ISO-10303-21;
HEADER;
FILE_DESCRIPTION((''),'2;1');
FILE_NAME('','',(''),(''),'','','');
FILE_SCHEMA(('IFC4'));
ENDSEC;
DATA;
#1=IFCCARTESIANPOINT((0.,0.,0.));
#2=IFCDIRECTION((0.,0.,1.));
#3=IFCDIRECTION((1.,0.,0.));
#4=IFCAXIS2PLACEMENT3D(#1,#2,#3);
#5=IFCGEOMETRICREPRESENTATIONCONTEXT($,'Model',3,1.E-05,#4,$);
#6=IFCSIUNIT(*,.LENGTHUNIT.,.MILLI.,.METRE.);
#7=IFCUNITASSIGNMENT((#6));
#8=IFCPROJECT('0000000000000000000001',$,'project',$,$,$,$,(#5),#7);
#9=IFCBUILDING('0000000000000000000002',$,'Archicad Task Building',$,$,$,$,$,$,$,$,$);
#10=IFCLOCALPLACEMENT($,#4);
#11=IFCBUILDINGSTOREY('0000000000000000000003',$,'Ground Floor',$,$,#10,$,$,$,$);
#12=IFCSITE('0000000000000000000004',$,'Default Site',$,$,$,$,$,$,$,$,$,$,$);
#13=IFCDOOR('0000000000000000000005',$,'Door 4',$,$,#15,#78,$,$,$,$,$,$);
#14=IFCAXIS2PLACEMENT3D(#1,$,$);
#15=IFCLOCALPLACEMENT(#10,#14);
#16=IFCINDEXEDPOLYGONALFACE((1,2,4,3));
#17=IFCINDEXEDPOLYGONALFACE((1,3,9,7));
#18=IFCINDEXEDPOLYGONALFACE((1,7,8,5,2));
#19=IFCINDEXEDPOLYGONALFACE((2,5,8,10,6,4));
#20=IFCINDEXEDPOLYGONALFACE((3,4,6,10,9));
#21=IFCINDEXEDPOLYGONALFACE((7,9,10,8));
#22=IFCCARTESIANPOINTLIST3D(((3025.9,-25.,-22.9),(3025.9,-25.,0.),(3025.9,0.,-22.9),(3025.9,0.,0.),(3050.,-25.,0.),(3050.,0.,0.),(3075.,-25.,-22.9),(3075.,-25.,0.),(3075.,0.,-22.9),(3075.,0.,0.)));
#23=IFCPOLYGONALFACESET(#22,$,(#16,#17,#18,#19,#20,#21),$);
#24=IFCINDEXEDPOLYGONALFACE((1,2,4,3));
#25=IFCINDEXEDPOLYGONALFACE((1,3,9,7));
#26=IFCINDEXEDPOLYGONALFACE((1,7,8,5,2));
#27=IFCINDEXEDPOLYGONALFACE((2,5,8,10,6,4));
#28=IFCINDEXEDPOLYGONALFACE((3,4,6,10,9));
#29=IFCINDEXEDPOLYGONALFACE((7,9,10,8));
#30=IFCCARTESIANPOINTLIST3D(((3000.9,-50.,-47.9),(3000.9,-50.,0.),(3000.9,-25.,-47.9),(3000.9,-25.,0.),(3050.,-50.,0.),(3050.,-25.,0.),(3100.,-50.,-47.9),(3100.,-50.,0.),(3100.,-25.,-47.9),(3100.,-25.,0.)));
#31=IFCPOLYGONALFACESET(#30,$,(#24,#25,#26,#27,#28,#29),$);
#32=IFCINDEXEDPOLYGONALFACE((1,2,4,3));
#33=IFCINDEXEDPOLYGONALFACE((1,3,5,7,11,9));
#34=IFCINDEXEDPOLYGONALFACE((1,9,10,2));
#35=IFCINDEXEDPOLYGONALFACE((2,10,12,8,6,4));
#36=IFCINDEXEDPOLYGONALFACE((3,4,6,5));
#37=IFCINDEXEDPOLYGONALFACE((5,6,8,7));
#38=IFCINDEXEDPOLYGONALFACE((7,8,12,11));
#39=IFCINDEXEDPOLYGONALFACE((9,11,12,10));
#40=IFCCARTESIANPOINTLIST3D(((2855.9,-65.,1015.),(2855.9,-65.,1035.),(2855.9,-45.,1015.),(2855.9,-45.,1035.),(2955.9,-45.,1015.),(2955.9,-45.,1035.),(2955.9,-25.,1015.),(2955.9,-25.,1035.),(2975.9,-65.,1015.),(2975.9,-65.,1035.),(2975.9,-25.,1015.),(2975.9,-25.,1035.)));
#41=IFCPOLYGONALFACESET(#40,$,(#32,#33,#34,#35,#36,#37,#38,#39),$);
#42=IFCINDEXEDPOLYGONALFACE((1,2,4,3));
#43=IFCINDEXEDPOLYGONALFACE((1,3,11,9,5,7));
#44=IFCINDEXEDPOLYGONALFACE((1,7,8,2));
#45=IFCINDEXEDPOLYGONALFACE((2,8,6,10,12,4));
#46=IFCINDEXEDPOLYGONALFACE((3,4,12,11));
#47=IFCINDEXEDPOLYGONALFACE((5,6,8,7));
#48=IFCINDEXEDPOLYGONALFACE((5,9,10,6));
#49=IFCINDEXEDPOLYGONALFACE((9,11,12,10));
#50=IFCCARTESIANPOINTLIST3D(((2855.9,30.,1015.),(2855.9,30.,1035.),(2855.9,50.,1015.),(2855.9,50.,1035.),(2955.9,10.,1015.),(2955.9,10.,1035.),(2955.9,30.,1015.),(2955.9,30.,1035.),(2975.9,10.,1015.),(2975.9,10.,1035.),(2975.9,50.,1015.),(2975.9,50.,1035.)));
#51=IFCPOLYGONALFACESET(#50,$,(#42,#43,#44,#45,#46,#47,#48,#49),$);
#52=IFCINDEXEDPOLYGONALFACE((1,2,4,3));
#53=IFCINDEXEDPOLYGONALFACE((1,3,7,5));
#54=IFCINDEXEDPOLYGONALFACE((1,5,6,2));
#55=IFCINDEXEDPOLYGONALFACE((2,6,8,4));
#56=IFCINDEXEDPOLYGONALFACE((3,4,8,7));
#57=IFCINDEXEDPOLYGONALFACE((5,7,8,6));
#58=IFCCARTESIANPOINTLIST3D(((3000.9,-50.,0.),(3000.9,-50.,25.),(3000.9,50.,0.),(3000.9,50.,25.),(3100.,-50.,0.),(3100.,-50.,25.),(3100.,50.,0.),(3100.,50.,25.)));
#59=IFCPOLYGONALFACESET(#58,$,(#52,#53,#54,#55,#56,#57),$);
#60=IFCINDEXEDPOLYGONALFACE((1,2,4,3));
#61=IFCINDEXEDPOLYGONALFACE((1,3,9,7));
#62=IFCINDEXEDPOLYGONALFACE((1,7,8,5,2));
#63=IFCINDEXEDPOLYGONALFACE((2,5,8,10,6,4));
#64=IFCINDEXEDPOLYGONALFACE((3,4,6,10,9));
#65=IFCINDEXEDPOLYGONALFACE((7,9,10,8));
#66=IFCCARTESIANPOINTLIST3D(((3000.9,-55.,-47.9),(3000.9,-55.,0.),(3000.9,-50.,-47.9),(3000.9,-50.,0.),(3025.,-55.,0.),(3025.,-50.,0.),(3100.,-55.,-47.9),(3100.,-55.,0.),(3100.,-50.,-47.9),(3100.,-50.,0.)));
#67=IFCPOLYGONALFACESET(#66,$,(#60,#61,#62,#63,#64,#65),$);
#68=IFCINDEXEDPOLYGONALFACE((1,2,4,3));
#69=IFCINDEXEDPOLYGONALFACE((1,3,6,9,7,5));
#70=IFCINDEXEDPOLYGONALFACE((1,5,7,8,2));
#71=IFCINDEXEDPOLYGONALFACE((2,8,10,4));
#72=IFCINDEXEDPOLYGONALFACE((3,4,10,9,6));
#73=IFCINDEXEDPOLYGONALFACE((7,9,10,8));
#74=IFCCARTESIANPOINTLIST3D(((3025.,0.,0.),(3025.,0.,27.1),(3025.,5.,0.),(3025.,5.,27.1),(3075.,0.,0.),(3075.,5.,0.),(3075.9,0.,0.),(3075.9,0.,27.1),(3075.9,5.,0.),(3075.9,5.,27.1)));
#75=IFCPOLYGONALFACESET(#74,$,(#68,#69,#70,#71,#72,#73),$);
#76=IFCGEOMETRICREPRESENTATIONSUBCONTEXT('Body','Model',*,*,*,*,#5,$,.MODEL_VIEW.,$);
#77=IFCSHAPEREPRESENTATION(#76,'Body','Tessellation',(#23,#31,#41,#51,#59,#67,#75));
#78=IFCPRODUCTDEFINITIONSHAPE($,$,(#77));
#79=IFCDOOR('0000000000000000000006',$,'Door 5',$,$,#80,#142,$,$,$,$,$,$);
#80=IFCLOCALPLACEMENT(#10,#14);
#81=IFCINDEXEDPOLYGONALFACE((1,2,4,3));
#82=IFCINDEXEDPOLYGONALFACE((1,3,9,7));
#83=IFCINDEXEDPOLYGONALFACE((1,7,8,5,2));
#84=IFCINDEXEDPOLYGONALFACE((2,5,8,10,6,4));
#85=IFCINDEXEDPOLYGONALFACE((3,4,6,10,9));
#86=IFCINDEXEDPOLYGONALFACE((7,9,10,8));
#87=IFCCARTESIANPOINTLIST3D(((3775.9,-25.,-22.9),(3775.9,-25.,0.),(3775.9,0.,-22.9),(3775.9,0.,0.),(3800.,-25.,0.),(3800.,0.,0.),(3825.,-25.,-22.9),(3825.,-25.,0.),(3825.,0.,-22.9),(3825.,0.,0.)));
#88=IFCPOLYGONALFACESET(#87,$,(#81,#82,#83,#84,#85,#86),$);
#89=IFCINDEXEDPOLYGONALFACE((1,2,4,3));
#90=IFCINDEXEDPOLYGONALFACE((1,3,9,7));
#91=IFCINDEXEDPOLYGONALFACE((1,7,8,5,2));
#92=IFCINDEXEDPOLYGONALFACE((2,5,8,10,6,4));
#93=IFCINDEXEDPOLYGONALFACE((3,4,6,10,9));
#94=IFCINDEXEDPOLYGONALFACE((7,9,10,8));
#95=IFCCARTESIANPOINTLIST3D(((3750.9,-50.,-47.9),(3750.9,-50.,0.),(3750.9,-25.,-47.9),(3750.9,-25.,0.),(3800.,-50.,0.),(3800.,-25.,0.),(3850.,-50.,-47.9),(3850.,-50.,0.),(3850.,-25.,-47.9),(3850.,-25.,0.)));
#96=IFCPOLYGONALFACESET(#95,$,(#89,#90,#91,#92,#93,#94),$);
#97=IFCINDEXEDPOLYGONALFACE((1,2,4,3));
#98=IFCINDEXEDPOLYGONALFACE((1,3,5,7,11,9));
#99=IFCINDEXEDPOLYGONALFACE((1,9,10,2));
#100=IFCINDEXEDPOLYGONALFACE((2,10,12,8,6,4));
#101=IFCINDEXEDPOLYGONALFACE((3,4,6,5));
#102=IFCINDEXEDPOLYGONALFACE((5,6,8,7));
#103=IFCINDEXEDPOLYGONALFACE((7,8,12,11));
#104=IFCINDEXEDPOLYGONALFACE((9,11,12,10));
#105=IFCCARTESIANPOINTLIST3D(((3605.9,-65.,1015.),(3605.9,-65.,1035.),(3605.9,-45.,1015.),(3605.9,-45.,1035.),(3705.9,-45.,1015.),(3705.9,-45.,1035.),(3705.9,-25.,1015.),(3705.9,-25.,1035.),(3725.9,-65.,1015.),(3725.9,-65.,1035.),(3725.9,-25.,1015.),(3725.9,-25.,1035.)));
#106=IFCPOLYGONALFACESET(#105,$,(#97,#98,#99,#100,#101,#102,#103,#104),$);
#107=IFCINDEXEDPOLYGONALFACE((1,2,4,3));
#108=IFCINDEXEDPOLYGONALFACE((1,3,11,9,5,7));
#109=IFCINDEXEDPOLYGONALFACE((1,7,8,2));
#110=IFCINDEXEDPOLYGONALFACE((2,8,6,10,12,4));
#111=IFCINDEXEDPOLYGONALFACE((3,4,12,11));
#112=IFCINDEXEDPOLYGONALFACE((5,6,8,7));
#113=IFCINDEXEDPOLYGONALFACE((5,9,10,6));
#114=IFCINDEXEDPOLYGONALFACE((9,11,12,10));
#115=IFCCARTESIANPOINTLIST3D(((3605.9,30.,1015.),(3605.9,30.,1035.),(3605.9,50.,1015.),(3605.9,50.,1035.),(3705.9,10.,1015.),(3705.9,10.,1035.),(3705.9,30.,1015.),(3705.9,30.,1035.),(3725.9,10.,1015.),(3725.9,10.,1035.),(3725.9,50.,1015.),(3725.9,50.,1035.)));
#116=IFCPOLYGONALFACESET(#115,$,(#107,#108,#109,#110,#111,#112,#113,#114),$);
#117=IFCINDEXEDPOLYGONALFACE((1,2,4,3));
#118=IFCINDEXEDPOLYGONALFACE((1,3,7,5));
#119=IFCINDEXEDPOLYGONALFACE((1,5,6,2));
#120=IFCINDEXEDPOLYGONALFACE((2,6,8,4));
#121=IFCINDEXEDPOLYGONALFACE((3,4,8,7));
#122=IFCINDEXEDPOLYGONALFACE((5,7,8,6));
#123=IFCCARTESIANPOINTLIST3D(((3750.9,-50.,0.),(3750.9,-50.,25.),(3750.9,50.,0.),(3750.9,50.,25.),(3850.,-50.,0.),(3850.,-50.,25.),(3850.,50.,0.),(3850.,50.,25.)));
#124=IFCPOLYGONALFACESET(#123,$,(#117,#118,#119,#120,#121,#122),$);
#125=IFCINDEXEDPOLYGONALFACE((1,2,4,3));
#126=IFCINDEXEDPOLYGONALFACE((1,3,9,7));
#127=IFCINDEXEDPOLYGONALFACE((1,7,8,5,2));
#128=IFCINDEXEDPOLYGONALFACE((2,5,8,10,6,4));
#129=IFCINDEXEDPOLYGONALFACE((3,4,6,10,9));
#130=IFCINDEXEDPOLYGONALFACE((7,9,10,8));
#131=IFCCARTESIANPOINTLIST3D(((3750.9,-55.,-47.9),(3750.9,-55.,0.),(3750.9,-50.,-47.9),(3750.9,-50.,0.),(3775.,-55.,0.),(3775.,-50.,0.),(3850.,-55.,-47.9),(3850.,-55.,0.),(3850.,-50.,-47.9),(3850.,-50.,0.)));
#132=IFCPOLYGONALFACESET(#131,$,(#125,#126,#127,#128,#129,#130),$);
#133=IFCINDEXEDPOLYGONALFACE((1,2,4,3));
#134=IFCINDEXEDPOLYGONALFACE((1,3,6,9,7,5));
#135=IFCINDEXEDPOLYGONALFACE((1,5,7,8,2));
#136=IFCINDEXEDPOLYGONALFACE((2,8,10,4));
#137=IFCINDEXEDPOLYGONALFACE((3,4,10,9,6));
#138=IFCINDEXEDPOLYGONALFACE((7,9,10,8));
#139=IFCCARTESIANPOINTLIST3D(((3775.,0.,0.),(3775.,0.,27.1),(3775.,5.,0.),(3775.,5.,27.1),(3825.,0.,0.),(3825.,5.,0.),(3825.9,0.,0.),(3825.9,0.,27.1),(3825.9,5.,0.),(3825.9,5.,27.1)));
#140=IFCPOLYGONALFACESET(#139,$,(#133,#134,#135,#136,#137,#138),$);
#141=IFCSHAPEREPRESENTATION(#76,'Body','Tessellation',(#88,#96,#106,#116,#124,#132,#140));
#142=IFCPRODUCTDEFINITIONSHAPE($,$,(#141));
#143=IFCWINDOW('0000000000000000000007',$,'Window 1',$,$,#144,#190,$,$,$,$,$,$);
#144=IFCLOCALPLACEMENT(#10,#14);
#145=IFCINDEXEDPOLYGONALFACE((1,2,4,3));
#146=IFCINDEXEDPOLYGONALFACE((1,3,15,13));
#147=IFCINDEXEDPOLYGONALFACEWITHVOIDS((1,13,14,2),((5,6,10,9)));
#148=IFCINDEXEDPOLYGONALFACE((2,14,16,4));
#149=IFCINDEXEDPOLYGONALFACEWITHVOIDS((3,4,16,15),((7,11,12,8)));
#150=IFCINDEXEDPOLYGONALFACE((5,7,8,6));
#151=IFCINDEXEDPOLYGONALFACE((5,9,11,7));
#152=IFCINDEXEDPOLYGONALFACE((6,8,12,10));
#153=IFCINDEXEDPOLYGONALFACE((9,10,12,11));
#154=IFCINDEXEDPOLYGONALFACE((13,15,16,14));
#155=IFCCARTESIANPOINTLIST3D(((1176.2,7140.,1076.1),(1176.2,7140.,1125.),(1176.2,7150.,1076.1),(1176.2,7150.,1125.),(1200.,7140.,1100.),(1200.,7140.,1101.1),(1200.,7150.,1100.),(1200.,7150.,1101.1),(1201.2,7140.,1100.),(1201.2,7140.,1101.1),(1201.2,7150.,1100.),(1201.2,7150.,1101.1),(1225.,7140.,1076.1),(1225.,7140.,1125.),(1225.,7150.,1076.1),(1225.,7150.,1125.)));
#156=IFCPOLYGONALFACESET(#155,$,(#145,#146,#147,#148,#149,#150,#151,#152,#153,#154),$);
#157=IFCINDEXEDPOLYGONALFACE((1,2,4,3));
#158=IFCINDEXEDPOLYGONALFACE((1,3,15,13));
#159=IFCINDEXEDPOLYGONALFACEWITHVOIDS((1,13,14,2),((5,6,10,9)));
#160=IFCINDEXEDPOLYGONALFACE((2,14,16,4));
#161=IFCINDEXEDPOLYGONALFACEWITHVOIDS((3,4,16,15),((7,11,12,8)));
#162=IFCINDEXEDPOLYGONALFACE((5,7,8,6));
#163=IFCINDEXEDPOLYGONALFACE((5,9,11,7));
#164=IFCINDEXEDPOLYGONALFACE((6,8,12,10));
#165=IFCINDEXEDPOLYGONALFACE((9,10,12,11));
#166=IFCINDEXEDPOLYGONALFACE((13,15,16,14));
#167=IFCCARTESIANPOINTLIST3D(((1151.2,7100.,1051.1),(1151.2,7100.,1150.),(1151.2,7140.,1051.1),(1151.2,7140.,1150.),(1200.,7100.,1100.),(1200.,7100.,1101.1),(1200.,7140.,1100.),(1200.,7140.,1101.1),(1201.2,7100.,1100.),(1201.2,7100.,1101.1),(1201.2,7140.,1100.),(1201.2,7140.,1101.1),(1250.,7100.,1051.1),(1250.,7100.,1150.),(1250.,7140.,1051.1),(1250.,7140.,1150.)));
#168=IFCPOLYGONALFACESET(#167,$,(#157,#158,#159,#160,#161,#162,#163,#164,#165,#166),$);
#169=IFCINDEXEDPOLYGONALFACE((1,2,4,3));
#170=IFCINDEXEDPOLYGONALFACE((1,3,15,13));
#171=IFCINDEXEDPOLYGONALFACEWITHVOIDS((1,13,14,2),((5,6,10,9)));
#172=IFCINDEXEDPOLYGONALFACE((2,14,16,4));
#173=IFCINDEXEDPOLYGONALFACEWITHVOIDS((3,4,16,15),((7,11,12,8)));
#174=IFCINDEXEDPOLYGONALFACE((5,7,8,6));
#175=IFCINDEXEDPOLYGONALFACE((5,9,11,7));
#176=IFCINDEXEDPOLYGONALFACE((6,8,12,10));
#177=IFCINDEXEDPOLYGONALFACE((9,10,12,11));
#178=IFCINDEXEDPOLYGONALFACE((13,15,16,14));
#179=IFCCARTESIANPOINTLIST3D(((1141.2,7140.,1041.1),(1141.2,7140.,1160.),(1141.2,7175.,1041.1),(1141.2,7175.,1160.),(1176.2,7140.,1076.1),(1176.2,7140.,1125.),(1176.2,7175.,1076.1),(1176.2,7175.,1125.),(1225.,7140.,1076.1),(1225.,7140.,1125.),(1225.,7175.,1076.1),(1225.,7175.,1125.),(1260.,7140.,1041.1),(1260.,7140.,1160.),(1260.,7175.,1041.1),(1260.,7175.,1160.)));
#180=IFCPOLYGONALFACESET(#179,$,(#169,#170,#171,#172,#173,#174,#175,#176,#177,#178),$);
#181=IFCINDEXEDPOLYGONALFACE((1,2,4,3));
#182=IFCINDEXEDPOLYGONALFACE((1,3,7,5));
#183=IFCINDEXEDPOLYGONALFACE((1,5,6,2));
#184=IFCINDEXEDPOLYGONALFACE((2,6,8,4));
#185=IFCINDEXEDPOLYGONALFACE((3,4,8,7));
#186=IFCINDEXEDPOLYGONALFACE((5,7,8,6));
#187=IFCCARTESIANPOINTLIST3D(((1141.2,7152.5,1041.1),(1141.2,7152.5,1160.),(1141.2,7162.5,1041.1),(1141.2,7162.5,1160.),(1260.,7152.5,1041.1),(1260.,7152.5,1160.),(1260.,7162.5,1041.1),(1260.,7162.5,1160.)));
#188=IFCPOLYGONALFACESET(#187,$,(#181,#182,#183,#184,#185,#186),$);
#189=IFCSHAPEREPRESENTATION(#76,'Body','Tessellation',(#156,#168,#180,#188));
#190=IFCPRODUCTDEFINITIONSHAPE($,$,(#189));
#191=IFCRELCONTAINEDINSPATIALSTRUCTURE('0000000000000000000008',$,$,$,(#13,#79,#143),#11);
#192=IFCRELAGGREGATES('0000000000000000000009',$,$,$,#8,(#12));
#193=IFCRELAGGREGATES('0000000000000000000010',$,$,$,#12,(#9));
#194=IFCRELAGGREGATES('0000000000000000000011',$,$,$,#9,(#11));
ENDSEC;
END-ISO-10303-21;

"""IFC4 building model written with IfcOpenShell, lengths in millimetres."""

from ifc_helpers import new_model, si_unit, frame, origin_with_axes, place, context, subcontext, project, spatial, line, indexed_curve, outline, extrude, element, save


model = new_model("IFC4")

# Units and contexts
model_context = context("Model", 3, precision=1e-05, world=origin_with_axes())
body_context = subcontext(model_context, "Body", "Model", "MODEL_VIEW")
ifc_project = project(units=[si_unit("LENGTHUNIT", "METRE", prefix="MILLI")], contexts=[model_context])

# Site, building, storey
site = spatial("IfcSite", under=ifc_project, Name="Default Site")
building = spatial("IfcBuilding", under=site, Name="Archicad Task Building")
storey_placement = place(None, origin_with_axes())
storey = spatial("IfcBuildingStorey", under=building, at=storey_placement, Name="Ground Floor")

# Doors
door_1_placement = place(storey_placement, frame((3050.0, -50.0, 0.0), z_axis=(0.0, 0.0, 1.0), x_axis=(1.0, 0.0, 0.0)))
element("IfcDoor", 1, at=door_1_placement, inside=storey, Name="Door 4", context=body_context, shape_type="SweptSolid", body=[
    extrude(outline(indexed_curve([(0.0, 0.0), (0.0, 2.1), (0.9, 2.1), (0.9, 0.0), (-24.1, 0.0), (-24.1, -22.9), (25.0, -22.9), (25.0, 0.0)], segments=[line(1, 2, 3, 4, 5, 6, 7, 8, 1)])), frame((0.0, 25.0, 0.0), z_axis=(0.0, -1.0, 0.0), x_axis=(1.0, 0.0, 0.0)), (0.0, 0.0, -1.0), 25.0),
    extrude(outline(indexed_curve([(0.0, 0.0), (0.0, 2.1), (0.9, 2.1), (0.9, 0.0), (-49.1, 0.0), (-49.1, -47.9), (50.0, -47.9), (50.0, 0.0)], segments=[line(1, 2, 3, 4, 5, 6, 7, 8, 1)])), frame((0.0, 0.0, 0.0), z_axis=(0.0, -1.0, 0.0), x_axis=(1.0, 0.0, 0.0)), (0.0, 0.0, -1.0), 25.0),
    extrude(outline(indexed_curve([(0.0, 0.0), (-49.1, 0.0), (-49.1, 35.0), (0.0, 35.0)], segments=[line(1, 2, 3, 4, 1)])), frame((25.0, 25.0, 25.0), z_axis=(0.0, 0.0, 1.0), x_axis=(1.0, 0.0, 0.0)), (0.0, 0.0, 1.0), -47.9),
    extrude(outline(indexed_curve([(0.0, 0.0), (0.0, -40.0), (-120.0, -40.0), (-120.0, -20.0), (-20.0, -20.0), (-20.0, 0.0)], segments=[line(1, 2, 3, 4, 5, 6, 1)])), frame((-74.1, 25.0, 1015.0), z_axis=(0.0, 0.0, 1.0), x_axis=(1.0, 0.0, 0.0)), (0.0, 0.0, 1.0), 20.0),
    extrude(outline(indexed_curve([(0.0, 0.0), (0.0, 40.0), (-120.0, 40.0), (-120.0, 20.0), (-20.0, 20.0), (-20.0, 0.0)], segments=[line(1, 2, 3, 4, 5, 6, 1)])), frame((-74.1, 60.0, 1015.0), z_axis=(0.0, 0.0, 1.0), x_axis=(1.0, 0.0, 0.0)), (0.0, 0.0, 1.0), 20.0),
    extrude(outline(indexed_curve([(0.0, 0.0), (-99.1, 0.0), (-99.1, 100.0), (0.0, 100.0)], segments=[line(1, 2, 3, 4, 1)])), frame((50.0, 0.0, 0.0), z_axis=(0.0, 0.0, 1.0), x_axis=(1.0, 0.0, 0.0)), (0.0, 0.0, 1.0), 25.0),
    extrude(outline(indexed_curve([(0.0, 0.0), (0.0, 27.1), (50.9, 27.1), (50.9, 0.0), (-24.1, 0.0), (-24.1, -47.9), (75.0, -47.9), (75.0, 0.0)], segments=[line(1, 2, 3, 4, 5, 6, 7, 8, 1)])), frame((-25.0, -5.0, 0.0), z_axis=(0.0, -1.0, 0.0), x_axis=(1.0, 0.0, 0.0)), (0.0, 0.0, -1.0), 5.0),
    extrude(outline(indexed_curve([(0.0, 0.0), (0.0, 27.1), (50.9, 27.1), (50.9, 0.0), (0.9, 0.0), (0.9, -22.9), (50.0, -22.9), (50.0, 0.0)], segments=[line(1, 2, 3, 4, 5, 6, 7, 8, 1)])), frame((-25.0, 50.0, 0.0), z_axis=(0.0, -1.0, 0.0), x_axis=(1.0, 0.0, 0.0)), (0.0, 0.0, -1.0), 5.0),
])
door_2_placement = place(storey_placement, frame((3800.0, -50.0, 0.0), z_axis=(0.0, 0.0, 1.0), x_axis=(1.0, 0.0, 0.0)))
element("IfcDoor", 2, at=door_2_placement, inside=storey, Name="Door 5", context=body_context, shape_type="SweptSolid", body=[
    extrude(outline(indexed_curve([(0.0, 0.0), (0.0, 2.1), (0.9, 2.1), (0.9, 0.0), (-24.1, 0.0), (-24.1, -22.9), (25.0, -22.9), (25.0, 0.0)], segments=[line(1, 2, 3, 4, 5, 6, 7, 8, 1)])), frame((0.0, 25.0, 0.0), z_axis=(0.0, -1.0, 0.0), x_axis=(1.0, 0.0, 0.0)), (0.0, 0.0, -1.0), 25.0),
    extrude(outline(indexed_curve([(0.0, 0.0), (0.0, 2.1), (0.9, 2.1), (0.9, 0.0), (-49.1, 0.0), (-49.1, -47.9), (50.0, -47.9), (50.0, 0.0)], segments=[line(1, 2, 3, 4, 5, 6, 7, 8, 1)])), frame((0.0, 0.0, 0.0), z_axis=(0.0, -1.0, 0.0), x_axis=(1.0, 0.0, 0.0)), (0.0, 0.0, -1.0), 25.0),
    extrude(outline(indexed_curve([(0.0, 0.0), (-49.1, 0.0), (-49.1, 35.0), (0.0, 35.0)], segments=[line(1, 2, 3, 4, 1)])), frame((25.0, 25.0, 25.0), z_axis=(0.0, 0.0, 1.0), x_axis=(1.0, 0.0, 0.0)), (0.0, 0.0, 1.0), -47.9),
    extrude(outline(indexed_curve([(0.0, 0.0), (0.0, -40.0), (-120.0, -40.0), (-120.0, -20.0), (-20.0, -20.0), (-20.0, 0.0)], segments=[line(1, 2, 3, 4, 5, 6, 1)])), frame((-74.1, 25.0, 1015.0), z_axis=(0.0, 0.0, 1.0), x_axis=(1.0, 0.0, 0.0)), (0.0, 0.0, 1.0), 20.0),
    extrude(outline(indexed_curve([(0.0, 0.0), (0.0, 40.0), (-120.0, 40.0), (-120.0, 20.0), (-20.0, 20.0), (-20.0, 0.0)], segments=[line(1, 2, 3, 4, 5, 6, 1)])), frame((-74.1, 60.0, 1015.0), z_axis=(0.0, 0.0, 1.0), x_axis=(1.0, 0.0, 0.0)), (0.0, 0.0, 1.0), 20.0),
    extrude(outline(indexed_curve([(0.0, 0.0), (-99.1, 0.0), (-99.1, 100.0), (0.0, 100.0)], segments=[line(1, 2, 3, 4, 1)])), frame((50.0, 0.0, 0.0), z_axis=(0.0, 0.0, 1.0), x_axis=(1.0, 0.0, 0.0)), (0.0, 0.0, 1.0), 25.0),
    extrude(outline(indexed_curve([(0.0, 0.0), (0.0, 27.1), (50.9, 27.1), (50.9, 0.0), (-24.1, 0.0), (-24.1, -47.9), (75.0, -47.9), (75.0, 0.0)], segments=[line(1, 2, 3, 4, 5, 6, 7, 8, 1)])), frame((-25.0, -5.0, 0.0), z_axis=(0.0, -1.0, 0.0), x_axis=(1.0, 0.0, 0.0)), (0.0, 0.0, -1.0), 5.0),
    extrude(outline(indexed_curve([(0.0, 0.0), (0.0, 27.1), (50.9, 27.1), (50.9, 0.0), (0.9, 0.0), (0.9, -22.9), (50.0, -22.9), (50.0, 0.0)], segments=[line(1, 2, 3, 4, 5, 6, 7, 8, 1)])), frame((-25.0, 50.0, 0.0), z_axis=(0.0, -1.0, 0.0), x_axis=(1.0, 0.0, 0.0)), (0.0, 0.0, -1.0), 5.0),
])

# Window
for number, where, z_axis, x_axis, name in (
    (3, (1200.0, 7050.0, 1100.0), (0.0, 0.0, 1.0), (1.0, 0.0, 0.0), "Window 1"),
):
    element("IfcWindow", number, at=place(storey_placement, frame(where, z_axis=z_axis, x_axis=x_axis)), inside=storey, Name=name, context=body_context, shape_type="SweptSolid", body=[
        extrude(outline(indexed_curve([(0.0, 0.0), (1.2, 0.0), (1.2, 1.1), (0.0, 1.1)], segments=[line(1, 2, 3, 4, 1)]), holes=[indexed_curve([(25.0, 25.0), (-23.8, 25.0), (-23.8, -23.9), (25.0, -23.9)], segments=[line(1, 2, 3, 4, 1)])]), frame((0.0, 90.0, 0.0), z_axis=(0.0, -1.0, 0.0), x_axis=(1.0, 0.0, 0.0)), (0.0, 0.0, -1.0), 10.0),
        extrude(outline(indexed_curve([(0.0, 0.0), (1.2, 0.0), (1.2, 1.1), (0.0, 1.1)], segments=[line(1, 2, 3, 4, 1)]), holes=[indexed_curve([(50.0, 50.0), (-48.8, 50.0), (-48.8, -48.9), (50.0, -48.9)], segments=[line(1, 2, 3, 4, 1)])]), frame((0.0, 50.0, 0.0), z_axis=(0.0, -1.0, 0.0), x_axis=(1.0, 0.0, 0.0)), (0.0, 0.0, -1.0), 40.0),
        extrude(outline(indexed_curve([(0.0, 0.0), (-48.8, 0.0), (-48.8, -48.9), (0.0, -48.9)], segments=[line(1, 2, 3, 4, 1)]), holes=[indexed_curve([(35.0, 35.0), (-83.8, 35.0), (-83.8, -83.9), (35.0, -83.9)], segments=[line(1, 2, 3, 4, 1)])]), frame((25.0, 90.0, 25.0), z_axis=(0.0, -1.0, 0.0), x_axis=(1.0, 0.0, 0.0)), (0.0, 0.0, -1.0), 35.0),
        extrude(outline(indexed_curve([(35.0, 35.0), (-83.8, 35.0), (-83.8, -83.9), (35.0, -83.9)], segments=[line(1, 2, 3, 4, 1)])), frame((25.0, 102.5, 25.0), z_axis=(0.0, -1.0, 0.0), x_axis=(1.0, 0.0, 0.0)), (0.0, 0.0, -1.0), 10.0),
    ])

save(model, "model.ifc")
